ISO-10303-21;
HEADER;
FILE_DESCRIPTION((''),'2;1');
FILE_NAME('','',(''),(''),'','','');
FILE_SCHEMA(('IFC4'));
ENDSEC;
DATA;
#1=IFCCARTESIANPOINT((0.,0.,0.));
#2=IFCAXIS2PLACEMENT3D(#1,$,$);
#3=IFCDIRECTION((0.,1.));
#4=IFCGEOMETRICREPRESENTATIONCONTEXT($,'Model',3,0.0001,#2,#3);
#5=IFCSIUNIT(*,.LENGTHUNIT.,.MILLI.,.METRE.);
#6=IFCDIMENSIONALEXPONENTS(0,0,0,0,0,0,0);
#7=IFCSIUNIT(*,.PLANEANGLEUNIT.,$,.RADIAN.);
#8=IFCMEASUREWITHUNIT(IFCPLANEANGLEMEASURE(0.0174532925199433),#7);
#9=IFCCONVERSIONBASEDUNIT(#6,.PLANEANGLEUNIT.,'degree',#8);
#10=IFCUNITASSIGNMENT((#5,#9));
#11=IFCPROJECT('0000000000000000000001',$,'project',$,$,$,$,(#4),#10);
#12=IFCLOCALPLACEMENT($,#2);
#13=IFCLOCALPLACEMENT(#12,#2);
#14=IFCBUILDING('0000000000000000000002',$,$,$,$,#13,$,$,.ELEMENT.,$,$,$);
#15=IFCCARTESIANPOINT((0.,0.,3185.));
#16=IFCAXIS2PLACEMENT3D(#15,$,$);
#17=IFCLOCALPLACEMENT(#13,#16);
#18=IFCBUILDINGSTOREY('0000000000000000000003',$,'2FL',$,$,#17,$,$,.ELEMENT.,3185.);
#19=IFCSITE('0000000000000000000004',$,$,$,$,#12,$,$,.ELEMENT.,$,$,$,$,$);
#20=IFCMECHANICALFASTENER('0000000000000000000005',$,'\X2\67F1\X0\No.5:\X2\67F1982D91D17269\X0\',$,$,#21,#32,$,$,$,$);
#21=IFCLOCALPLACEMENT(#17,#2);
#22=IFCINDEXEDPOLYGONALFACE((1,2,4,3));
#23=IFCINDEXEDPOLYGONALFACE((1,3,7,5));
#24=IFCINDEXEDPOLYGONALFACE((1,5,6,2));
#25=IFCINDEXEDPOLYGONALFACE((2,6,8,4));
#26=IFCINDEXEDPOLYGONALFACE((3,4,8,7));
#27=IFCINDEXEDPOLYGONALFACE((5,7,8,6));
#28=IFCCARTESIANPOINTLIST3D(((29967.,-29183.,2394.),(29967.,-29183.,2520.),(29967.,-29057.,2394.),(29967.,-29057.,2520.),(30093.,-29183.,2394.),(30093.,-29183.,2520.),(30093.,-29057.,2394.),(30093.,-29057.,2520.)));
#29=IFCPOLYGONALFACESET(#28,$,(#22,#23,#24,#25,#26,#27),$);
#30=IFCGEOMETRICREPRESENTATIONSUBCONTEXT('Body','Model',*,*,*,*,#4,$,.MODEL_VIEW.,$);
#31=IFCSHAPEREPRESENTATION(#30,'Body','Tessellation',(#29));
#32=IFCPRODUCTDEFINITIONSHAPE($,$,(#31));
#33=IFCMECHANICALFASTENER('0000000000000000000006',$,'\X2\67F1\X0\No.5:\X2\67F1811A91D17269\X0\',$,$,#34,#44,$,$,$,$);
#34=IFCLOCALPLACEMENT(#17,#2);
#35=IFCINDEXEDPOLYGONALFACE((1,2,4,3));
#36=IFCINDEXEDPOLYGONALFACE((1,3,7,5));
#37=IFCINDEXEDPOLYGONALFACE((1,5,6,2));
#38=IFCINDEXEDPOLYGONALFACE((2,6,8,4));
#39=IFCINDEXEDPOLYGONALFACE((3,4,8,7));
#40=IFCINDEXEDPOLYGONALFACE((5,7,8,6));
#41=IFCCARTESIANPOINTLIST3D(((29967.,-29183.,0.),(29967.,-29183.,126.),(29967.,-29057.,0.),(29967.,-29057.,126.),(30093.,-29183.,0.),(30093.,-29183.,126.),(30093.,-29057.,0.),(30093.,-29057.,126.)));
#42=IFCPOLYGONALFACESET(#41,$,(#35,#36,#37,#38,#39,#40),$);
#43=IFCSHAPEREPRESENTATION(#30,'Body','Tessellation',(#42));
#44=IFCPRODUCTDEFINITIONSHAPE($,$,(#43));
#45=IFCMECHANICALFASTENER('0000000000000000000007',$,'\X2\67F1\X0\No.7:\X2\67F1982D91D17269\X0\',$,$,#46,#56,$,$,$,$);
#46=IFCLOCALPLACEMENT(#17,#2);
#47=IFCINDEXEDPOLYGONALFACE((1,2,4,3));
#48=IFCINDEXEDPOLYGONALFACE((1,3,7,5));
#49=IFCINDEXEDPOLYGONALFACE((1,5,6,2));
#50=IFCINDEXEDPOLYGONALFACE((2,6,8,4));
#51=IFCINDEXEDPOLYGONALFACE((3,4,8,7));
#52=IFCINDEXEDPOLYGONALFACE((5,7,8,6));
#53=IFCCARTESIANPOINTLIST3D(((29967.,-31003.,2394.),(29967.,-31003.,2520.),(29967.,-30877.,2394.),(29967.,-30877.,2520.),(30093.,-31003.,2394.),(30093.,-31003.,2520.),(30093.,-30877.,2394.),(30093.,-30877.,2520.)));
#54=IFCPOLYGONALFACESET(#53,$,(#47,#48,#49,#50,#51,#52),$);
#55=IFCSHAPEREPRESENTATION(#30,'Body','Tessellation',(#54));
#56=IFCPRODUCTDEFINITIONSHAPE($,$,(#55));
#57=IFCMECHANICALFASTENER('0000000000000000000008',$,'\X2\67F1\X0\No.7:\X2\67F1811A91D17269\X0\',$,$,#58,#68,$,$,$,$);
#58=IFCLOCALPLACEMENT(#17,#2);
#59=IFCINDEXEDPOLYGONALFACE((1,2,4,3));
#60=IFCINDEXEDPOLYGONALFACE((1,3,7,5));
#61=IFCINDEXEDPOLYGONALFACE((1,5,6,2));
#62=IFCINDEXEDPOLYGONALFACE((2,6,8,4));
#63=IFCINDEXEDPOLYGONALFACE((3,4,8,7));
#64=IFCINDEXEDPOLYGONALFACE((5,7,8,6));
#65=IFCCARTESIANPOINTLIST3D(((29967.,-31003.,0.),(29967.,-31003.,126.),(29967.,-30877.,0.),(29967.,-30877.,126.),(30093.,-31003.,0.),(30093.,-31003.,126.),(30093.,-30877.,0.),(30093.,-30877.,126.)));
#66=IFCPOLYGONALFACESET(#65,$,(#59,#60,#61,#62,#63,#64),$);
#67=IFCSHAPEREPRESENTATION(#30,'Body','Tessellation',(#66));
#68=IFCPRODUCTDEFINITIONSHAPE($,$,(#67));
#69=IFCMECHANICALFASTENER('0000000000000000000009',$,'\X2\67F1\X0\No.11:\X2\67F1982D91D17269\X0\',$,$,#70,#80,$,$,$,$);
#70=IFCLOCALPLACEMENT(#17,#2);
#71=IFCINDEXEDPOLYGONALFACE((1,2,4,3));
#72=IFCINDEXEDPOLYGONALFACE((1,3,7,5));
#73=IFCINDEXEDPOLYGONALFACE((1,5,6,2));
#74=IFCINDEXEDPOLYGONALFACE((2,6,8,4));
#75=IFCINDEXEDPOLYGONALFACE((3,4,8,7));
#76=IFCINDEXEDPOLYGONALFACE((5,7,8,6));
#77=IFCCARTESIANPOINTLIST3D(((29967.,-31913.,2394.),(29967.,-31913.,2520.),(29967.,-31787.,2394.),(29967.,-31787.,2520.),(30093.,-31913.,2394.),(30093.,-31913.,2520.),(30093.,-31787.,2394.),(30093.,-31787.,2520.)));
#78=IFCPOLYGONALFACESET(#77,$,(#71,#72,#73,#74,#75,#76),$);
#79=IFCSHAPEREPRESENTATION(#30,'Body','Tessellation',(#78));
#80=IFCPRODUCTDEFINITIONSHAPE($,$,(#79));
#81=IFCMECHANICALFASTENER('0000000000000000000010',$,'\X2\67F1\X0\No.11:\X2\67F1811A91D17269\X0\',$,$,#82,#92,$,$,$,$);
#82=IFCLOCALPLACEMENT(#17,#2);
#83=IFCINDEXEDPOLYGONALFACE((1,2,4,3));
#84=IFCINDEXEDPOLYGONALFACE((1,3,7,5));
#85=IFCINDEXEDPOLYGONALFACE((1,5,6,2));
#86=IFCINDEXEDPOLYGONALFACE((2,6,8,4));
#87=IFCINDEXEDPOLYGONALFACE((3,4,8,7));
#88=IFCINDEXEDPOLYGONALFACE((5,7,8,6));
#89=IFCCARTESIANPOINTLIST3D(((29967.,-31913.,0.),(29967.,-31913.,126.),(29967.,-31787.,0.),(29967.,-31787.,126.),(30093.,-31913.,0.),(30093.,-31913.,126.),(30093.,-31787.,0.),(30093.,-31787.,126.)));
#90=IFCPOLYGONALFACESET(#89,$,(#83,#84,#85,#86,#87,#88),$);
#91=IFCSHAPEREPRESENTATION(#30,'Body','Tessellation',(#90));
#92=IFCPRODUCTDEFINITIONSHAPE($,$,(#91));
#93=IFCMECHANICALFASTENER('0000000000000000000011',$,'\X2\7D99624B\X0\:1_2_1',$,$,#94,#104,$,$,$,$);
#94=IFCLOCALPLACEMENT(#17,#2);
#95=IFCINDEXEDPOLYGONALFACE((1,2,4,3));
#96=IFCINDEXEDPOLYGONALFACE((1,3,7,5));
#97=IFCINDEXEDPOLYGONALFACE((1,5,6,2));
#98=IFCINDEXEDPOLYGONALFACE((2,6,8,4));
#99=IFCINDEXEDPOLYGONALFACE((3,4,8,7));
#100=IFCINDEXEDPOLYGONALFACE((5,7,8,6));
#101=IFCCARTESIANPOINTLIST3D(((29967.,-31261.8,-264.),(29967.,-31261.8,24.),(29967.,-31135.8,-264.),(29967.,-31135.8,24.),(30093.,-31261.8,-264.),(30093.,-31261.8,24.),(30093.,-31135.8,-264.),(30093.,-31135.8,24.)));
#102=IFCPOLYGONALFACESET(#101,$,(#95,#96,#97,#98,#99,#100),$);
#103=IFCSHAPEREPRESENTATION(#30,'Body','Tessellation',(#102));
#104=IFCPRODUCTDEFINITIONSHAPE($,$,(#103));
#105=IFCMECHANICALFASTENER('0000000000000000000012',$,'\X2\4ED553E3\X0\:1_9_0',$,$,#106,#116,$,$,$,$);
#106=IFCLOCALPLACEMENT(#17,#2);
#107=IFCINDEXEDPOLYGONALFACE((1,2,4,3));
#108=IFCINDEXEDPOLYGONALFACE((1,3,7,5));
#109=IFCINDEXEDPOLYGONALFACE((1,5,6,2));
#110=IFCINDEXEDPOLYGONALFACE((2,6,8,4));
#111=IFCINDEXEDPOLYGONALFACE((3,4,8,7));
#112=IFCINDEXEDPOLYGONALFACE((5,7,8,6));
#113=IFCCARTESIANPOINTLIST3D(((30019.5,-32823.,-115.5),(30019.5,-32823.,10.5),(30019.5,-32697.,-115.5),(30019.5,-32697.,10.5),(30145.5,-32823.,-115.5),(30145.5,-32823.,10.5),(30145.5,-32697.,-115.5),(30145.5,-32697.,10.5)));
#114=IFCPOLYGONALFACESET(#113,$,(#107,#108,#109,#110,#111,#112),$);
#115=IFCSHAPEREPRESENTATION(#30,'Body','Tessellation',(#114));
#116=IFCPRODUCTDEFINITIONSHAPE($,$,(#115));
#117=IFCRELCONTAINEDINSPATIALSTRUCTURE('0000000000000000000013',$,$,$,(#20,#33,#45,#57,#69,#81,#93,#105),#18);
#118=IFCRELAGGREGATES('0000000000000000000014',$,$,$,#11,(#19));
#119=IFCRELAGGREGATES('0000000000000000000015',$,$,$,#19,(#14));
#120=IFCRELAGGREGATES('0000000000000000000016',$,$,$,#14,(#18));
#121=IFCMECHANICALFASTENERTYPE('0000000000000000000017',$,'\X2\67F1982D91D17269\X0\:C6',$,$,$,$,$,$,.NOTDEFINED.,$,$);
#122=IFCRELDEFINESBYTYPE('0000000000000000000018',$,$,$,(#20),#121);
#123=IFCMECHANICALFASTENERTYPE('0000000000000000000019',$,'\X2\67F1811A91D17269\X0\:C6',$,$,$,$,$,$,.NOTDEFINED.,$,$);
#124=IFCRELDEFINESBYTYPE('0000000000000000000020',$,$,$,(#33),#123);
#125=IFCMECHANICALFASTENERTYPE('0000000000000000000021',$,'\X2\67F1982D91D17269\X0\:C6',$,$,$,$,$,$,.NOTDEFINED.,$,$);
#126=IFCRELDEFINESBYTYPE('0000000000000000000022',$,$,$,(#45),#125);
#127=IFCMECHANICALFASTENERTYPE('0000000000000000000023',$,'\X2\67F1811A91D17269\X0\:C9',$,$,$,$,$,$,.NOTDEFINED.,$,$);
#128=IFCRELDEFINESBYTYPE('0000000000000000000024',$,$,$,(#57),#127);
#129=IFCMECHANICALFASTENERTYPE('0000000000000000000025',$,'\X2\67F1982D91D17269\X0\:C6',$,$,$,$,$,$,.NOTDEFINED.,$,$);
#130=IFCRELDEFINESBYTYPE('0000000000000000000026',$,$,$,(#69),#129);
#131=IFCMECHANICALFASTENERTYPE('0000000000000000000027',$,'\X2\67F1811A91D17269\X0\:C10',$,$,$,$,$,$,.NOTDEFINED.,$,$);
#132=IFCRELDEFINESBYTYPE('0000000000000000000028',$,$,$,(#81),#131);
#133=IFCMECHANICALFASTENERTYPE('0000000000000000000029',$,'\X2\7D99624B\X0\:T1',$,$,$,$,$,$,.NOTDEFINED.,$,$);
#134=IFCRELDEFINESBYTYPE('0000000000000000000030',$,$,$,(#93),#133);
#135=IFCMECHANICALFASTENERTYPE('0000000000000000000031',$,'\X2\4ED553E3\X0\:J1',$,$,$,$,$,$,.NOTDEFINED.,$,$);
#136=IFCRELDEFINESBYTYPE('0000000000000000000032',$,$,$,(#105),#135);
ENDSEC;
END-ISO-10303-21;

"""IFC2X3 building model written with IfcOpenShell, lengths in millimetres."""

from ifc_helpers import new_model, entity, si_unit, converted_unit, direction, frame, origin, origin_with_axes, origin_2d, place, context, subcontext, project, spatial, rectangle, extrude, type_object, element, save


model = new_model("IFC2X3")

# Units and contexts
model_context = context("Model", 3, precision=0.0001, world=origin(), true_north=direction((0.0, 1.0)))
body_context = subcontext(model_context, "Body", "Model", "MODEL_VIEW")
ifc_project = project(units=[si_unit("LENGTHUNIT", "METRE", prefix="MILLI"), converted_unit("PLANEANGLEUNIT", "degree", entity("IfcPlaneAngleMeasure", 0.0174532925199433), si_unit("PLANEANGLEUNIT", "RADIAN"), dimensions=[0, 0, 0, 0, 0, 0, 0])], contexts=[model_context])

# Site, building, storey
site_placement = place(None, origin())
site = spatial("IfcSite", under=ifc_project, at=site_placement, CompositionType="ELEMENT")
building_placement = place(site_placement, origin())
building = spatial("IfcBuilding", under=site, at=building_placement, CompositionType="ELEMENT")
storey_placement = place(building_placement, frame((0.0, 0.0, 3185.0)))
storey = spatial("IfcBuildingStorey", under=building, at=storey_placement, Name="2FL", CompositionType="ELEMENT", Elevation=3185.0)

# Mechanical fasteners
mechanical_fastener_type_1 = type_object("IfcMechanicalFastenerType", Name="柱頭金物:C6")
mechanical_fastener_1_placement = place(storey_placement, frame((30030.0, -29120.0, 2394.0)))
element("IfcMechanicalFastener", 1, at=mechanical_fastener_1_placement, inside=storey, type_object=mechanical_fastener_type_1, Name="柱No.5:柱頭金物", context=body_context, shape_type="SweptSolid", body=[
    extrude(rectangle(XDim=126.0, YDim=126.0, at=origin_2d()), origin_with_axes(), (0.0, 0.0, 1.0), 126.0),
])
mechanical_fastener_type_2 = type_object("IfcMechanicalFastenerType", Name="柱脚金物:C6")
mechanical_fastener_2_placement = place(storey_placement, frame((30030.0, -29120.0, 0.0)))
element("IfcMechanicalFastener", 2, at=mechanical_fastener_2_placement, inside=storey, type_object=mechanical_fastener_type_2, Name="柱No.5:柱脚金物", context=body_context, shape_type="SweptSolid", body=[
    extrude(rectangle(XDim=126.0, YDim=126.0, at=origin_2d()), origin_with_axes(), (0.0, 0.0, 1.0), 126.0),
])
mechanical_fastener_type_3 = type_object("IfcMechanicalFastenerType", Name="柱頭金物:C6")
mechanical_fastener_3_placement = place(storey_placement, frame((30030.0, -30940.0, 2394.0)))
element("IfcMechanicalFastener", 3, at=mechanical_fastener_3_placement, inside=storey, type_object=mechanical_fastener_type_3, Name="柱No.7:柱頭金物", context=body_context, shape_type="SweptSolid", body=[
    extrude(rectangle(XDim=126.0, YDim=126.0, at=origin_2d()), origin_with_axes(), (0.0, 0.0, 1.0), 126.0),
])
mechanical_fastener_type_4 = type_object("IfcMechanicalFastenerType", Name="柱脚金物:C9")
mechanical_fastener_4_placement = place(storey_placement, frame((30030.0, -30940.0, 0.0)))
element("IfcMechanicalFastener", 4, at=mechanical_fastener_4_placement, inside=storey, type_object=mechanical_fastener_type_4, Name="柱No.7:柱脚金物", context=body_context, shape_type="SweptSolid", body=[
    extrude(rectangle(XDim=126.0, YDim=126.0, at=origin_2d()), origin_with_axes(), (0.0, 0.0, 1.0), 126.0),
])
mechanical_fastener_type_5 = type_object("IfcMechanicalFastenerType", Name="柱頭金物:C6")
mechanical_fastener_5_placement = place(storey_placement, frame((30030.0, -31850.0, 2394.0)))
element("IfcMechanicalFastener", 5, at=mechanical_fastener_5_placement, inside=storey, type_object=mechanical_fastener_type_5, Name="柱No.11:柱頭金物", context=body_context, shape_type="SweptSolid", body=[
    extrude(rectangle(XDim=126.0, YDim=126.0, at=origin_2d()), origin_with_axes(), (0.0, 0.0, 1.0), 126.0),
])
mechanical_fastener_type_6 = type_object("IfcMechanicalFastenerType", Name="柱脚金物:C10")
mechanical_fastener_6_placement = place(storey_placement, frame((30030.0, -31850.0, 0.0)))
element("IfcMechanicalFastener", 6, at=mechanical_fastener_6_placement, inside=storey, type_object=mechanical_fastener_type_6, Name="柱No.11:柱脚金物", context=body_context, shape_type="SweptSolid", body=[
    extrude(rectangle(XDim=126.0, YDim=126.0, at=origin_2d()), origin_with_axes(), (0.0, 0.0, 1.0), 126.0),
])
mechanical_fastener_type_7 = type_object("IfcMechanicalFastenerType", Name="継手:T1")
mechanical_fastener_7_placement = place(storey_placement, frame((30030.0, -31198.8, -264.0)))
element("IfcMechanicalFastener", 7, at=mechanical_fastener_7_placement, inside=storey, type_object=mechanical_fastener_type_7, Name="継手:1_2_1", context=body_context, shape_type="SweptSolid", body=[
    extrude(rectangle(XDim=126.0, YDim=126.0, at=origin_2d()), origin_with_axes(), (0.0, 0.0, 1.0), 288.0),
])
mechanical_fastener_type_8 = type_object("IfcMechanicalFastenerType", Name="仕口:J1")
mechanical_fastener_8_placement = place(storey_placement, frame((30082.5, -32760.0, -115.5)))
element("IfcMechanicalFastener", 8, at=mechanical_fastener_8_placement, inside=storey, type_object=mechanical_fastener_type_8, Name="仕口:1_9_0", context=body_context, shape_type="SweptSolid", body=[
    extrude(rectangle(XDim=126.0, YDim=126.0, at=origin_2d()), origin_with_axes(), (0.0, 0.0, 1.0), 126.0),
])

save(model, "model.ifc")
